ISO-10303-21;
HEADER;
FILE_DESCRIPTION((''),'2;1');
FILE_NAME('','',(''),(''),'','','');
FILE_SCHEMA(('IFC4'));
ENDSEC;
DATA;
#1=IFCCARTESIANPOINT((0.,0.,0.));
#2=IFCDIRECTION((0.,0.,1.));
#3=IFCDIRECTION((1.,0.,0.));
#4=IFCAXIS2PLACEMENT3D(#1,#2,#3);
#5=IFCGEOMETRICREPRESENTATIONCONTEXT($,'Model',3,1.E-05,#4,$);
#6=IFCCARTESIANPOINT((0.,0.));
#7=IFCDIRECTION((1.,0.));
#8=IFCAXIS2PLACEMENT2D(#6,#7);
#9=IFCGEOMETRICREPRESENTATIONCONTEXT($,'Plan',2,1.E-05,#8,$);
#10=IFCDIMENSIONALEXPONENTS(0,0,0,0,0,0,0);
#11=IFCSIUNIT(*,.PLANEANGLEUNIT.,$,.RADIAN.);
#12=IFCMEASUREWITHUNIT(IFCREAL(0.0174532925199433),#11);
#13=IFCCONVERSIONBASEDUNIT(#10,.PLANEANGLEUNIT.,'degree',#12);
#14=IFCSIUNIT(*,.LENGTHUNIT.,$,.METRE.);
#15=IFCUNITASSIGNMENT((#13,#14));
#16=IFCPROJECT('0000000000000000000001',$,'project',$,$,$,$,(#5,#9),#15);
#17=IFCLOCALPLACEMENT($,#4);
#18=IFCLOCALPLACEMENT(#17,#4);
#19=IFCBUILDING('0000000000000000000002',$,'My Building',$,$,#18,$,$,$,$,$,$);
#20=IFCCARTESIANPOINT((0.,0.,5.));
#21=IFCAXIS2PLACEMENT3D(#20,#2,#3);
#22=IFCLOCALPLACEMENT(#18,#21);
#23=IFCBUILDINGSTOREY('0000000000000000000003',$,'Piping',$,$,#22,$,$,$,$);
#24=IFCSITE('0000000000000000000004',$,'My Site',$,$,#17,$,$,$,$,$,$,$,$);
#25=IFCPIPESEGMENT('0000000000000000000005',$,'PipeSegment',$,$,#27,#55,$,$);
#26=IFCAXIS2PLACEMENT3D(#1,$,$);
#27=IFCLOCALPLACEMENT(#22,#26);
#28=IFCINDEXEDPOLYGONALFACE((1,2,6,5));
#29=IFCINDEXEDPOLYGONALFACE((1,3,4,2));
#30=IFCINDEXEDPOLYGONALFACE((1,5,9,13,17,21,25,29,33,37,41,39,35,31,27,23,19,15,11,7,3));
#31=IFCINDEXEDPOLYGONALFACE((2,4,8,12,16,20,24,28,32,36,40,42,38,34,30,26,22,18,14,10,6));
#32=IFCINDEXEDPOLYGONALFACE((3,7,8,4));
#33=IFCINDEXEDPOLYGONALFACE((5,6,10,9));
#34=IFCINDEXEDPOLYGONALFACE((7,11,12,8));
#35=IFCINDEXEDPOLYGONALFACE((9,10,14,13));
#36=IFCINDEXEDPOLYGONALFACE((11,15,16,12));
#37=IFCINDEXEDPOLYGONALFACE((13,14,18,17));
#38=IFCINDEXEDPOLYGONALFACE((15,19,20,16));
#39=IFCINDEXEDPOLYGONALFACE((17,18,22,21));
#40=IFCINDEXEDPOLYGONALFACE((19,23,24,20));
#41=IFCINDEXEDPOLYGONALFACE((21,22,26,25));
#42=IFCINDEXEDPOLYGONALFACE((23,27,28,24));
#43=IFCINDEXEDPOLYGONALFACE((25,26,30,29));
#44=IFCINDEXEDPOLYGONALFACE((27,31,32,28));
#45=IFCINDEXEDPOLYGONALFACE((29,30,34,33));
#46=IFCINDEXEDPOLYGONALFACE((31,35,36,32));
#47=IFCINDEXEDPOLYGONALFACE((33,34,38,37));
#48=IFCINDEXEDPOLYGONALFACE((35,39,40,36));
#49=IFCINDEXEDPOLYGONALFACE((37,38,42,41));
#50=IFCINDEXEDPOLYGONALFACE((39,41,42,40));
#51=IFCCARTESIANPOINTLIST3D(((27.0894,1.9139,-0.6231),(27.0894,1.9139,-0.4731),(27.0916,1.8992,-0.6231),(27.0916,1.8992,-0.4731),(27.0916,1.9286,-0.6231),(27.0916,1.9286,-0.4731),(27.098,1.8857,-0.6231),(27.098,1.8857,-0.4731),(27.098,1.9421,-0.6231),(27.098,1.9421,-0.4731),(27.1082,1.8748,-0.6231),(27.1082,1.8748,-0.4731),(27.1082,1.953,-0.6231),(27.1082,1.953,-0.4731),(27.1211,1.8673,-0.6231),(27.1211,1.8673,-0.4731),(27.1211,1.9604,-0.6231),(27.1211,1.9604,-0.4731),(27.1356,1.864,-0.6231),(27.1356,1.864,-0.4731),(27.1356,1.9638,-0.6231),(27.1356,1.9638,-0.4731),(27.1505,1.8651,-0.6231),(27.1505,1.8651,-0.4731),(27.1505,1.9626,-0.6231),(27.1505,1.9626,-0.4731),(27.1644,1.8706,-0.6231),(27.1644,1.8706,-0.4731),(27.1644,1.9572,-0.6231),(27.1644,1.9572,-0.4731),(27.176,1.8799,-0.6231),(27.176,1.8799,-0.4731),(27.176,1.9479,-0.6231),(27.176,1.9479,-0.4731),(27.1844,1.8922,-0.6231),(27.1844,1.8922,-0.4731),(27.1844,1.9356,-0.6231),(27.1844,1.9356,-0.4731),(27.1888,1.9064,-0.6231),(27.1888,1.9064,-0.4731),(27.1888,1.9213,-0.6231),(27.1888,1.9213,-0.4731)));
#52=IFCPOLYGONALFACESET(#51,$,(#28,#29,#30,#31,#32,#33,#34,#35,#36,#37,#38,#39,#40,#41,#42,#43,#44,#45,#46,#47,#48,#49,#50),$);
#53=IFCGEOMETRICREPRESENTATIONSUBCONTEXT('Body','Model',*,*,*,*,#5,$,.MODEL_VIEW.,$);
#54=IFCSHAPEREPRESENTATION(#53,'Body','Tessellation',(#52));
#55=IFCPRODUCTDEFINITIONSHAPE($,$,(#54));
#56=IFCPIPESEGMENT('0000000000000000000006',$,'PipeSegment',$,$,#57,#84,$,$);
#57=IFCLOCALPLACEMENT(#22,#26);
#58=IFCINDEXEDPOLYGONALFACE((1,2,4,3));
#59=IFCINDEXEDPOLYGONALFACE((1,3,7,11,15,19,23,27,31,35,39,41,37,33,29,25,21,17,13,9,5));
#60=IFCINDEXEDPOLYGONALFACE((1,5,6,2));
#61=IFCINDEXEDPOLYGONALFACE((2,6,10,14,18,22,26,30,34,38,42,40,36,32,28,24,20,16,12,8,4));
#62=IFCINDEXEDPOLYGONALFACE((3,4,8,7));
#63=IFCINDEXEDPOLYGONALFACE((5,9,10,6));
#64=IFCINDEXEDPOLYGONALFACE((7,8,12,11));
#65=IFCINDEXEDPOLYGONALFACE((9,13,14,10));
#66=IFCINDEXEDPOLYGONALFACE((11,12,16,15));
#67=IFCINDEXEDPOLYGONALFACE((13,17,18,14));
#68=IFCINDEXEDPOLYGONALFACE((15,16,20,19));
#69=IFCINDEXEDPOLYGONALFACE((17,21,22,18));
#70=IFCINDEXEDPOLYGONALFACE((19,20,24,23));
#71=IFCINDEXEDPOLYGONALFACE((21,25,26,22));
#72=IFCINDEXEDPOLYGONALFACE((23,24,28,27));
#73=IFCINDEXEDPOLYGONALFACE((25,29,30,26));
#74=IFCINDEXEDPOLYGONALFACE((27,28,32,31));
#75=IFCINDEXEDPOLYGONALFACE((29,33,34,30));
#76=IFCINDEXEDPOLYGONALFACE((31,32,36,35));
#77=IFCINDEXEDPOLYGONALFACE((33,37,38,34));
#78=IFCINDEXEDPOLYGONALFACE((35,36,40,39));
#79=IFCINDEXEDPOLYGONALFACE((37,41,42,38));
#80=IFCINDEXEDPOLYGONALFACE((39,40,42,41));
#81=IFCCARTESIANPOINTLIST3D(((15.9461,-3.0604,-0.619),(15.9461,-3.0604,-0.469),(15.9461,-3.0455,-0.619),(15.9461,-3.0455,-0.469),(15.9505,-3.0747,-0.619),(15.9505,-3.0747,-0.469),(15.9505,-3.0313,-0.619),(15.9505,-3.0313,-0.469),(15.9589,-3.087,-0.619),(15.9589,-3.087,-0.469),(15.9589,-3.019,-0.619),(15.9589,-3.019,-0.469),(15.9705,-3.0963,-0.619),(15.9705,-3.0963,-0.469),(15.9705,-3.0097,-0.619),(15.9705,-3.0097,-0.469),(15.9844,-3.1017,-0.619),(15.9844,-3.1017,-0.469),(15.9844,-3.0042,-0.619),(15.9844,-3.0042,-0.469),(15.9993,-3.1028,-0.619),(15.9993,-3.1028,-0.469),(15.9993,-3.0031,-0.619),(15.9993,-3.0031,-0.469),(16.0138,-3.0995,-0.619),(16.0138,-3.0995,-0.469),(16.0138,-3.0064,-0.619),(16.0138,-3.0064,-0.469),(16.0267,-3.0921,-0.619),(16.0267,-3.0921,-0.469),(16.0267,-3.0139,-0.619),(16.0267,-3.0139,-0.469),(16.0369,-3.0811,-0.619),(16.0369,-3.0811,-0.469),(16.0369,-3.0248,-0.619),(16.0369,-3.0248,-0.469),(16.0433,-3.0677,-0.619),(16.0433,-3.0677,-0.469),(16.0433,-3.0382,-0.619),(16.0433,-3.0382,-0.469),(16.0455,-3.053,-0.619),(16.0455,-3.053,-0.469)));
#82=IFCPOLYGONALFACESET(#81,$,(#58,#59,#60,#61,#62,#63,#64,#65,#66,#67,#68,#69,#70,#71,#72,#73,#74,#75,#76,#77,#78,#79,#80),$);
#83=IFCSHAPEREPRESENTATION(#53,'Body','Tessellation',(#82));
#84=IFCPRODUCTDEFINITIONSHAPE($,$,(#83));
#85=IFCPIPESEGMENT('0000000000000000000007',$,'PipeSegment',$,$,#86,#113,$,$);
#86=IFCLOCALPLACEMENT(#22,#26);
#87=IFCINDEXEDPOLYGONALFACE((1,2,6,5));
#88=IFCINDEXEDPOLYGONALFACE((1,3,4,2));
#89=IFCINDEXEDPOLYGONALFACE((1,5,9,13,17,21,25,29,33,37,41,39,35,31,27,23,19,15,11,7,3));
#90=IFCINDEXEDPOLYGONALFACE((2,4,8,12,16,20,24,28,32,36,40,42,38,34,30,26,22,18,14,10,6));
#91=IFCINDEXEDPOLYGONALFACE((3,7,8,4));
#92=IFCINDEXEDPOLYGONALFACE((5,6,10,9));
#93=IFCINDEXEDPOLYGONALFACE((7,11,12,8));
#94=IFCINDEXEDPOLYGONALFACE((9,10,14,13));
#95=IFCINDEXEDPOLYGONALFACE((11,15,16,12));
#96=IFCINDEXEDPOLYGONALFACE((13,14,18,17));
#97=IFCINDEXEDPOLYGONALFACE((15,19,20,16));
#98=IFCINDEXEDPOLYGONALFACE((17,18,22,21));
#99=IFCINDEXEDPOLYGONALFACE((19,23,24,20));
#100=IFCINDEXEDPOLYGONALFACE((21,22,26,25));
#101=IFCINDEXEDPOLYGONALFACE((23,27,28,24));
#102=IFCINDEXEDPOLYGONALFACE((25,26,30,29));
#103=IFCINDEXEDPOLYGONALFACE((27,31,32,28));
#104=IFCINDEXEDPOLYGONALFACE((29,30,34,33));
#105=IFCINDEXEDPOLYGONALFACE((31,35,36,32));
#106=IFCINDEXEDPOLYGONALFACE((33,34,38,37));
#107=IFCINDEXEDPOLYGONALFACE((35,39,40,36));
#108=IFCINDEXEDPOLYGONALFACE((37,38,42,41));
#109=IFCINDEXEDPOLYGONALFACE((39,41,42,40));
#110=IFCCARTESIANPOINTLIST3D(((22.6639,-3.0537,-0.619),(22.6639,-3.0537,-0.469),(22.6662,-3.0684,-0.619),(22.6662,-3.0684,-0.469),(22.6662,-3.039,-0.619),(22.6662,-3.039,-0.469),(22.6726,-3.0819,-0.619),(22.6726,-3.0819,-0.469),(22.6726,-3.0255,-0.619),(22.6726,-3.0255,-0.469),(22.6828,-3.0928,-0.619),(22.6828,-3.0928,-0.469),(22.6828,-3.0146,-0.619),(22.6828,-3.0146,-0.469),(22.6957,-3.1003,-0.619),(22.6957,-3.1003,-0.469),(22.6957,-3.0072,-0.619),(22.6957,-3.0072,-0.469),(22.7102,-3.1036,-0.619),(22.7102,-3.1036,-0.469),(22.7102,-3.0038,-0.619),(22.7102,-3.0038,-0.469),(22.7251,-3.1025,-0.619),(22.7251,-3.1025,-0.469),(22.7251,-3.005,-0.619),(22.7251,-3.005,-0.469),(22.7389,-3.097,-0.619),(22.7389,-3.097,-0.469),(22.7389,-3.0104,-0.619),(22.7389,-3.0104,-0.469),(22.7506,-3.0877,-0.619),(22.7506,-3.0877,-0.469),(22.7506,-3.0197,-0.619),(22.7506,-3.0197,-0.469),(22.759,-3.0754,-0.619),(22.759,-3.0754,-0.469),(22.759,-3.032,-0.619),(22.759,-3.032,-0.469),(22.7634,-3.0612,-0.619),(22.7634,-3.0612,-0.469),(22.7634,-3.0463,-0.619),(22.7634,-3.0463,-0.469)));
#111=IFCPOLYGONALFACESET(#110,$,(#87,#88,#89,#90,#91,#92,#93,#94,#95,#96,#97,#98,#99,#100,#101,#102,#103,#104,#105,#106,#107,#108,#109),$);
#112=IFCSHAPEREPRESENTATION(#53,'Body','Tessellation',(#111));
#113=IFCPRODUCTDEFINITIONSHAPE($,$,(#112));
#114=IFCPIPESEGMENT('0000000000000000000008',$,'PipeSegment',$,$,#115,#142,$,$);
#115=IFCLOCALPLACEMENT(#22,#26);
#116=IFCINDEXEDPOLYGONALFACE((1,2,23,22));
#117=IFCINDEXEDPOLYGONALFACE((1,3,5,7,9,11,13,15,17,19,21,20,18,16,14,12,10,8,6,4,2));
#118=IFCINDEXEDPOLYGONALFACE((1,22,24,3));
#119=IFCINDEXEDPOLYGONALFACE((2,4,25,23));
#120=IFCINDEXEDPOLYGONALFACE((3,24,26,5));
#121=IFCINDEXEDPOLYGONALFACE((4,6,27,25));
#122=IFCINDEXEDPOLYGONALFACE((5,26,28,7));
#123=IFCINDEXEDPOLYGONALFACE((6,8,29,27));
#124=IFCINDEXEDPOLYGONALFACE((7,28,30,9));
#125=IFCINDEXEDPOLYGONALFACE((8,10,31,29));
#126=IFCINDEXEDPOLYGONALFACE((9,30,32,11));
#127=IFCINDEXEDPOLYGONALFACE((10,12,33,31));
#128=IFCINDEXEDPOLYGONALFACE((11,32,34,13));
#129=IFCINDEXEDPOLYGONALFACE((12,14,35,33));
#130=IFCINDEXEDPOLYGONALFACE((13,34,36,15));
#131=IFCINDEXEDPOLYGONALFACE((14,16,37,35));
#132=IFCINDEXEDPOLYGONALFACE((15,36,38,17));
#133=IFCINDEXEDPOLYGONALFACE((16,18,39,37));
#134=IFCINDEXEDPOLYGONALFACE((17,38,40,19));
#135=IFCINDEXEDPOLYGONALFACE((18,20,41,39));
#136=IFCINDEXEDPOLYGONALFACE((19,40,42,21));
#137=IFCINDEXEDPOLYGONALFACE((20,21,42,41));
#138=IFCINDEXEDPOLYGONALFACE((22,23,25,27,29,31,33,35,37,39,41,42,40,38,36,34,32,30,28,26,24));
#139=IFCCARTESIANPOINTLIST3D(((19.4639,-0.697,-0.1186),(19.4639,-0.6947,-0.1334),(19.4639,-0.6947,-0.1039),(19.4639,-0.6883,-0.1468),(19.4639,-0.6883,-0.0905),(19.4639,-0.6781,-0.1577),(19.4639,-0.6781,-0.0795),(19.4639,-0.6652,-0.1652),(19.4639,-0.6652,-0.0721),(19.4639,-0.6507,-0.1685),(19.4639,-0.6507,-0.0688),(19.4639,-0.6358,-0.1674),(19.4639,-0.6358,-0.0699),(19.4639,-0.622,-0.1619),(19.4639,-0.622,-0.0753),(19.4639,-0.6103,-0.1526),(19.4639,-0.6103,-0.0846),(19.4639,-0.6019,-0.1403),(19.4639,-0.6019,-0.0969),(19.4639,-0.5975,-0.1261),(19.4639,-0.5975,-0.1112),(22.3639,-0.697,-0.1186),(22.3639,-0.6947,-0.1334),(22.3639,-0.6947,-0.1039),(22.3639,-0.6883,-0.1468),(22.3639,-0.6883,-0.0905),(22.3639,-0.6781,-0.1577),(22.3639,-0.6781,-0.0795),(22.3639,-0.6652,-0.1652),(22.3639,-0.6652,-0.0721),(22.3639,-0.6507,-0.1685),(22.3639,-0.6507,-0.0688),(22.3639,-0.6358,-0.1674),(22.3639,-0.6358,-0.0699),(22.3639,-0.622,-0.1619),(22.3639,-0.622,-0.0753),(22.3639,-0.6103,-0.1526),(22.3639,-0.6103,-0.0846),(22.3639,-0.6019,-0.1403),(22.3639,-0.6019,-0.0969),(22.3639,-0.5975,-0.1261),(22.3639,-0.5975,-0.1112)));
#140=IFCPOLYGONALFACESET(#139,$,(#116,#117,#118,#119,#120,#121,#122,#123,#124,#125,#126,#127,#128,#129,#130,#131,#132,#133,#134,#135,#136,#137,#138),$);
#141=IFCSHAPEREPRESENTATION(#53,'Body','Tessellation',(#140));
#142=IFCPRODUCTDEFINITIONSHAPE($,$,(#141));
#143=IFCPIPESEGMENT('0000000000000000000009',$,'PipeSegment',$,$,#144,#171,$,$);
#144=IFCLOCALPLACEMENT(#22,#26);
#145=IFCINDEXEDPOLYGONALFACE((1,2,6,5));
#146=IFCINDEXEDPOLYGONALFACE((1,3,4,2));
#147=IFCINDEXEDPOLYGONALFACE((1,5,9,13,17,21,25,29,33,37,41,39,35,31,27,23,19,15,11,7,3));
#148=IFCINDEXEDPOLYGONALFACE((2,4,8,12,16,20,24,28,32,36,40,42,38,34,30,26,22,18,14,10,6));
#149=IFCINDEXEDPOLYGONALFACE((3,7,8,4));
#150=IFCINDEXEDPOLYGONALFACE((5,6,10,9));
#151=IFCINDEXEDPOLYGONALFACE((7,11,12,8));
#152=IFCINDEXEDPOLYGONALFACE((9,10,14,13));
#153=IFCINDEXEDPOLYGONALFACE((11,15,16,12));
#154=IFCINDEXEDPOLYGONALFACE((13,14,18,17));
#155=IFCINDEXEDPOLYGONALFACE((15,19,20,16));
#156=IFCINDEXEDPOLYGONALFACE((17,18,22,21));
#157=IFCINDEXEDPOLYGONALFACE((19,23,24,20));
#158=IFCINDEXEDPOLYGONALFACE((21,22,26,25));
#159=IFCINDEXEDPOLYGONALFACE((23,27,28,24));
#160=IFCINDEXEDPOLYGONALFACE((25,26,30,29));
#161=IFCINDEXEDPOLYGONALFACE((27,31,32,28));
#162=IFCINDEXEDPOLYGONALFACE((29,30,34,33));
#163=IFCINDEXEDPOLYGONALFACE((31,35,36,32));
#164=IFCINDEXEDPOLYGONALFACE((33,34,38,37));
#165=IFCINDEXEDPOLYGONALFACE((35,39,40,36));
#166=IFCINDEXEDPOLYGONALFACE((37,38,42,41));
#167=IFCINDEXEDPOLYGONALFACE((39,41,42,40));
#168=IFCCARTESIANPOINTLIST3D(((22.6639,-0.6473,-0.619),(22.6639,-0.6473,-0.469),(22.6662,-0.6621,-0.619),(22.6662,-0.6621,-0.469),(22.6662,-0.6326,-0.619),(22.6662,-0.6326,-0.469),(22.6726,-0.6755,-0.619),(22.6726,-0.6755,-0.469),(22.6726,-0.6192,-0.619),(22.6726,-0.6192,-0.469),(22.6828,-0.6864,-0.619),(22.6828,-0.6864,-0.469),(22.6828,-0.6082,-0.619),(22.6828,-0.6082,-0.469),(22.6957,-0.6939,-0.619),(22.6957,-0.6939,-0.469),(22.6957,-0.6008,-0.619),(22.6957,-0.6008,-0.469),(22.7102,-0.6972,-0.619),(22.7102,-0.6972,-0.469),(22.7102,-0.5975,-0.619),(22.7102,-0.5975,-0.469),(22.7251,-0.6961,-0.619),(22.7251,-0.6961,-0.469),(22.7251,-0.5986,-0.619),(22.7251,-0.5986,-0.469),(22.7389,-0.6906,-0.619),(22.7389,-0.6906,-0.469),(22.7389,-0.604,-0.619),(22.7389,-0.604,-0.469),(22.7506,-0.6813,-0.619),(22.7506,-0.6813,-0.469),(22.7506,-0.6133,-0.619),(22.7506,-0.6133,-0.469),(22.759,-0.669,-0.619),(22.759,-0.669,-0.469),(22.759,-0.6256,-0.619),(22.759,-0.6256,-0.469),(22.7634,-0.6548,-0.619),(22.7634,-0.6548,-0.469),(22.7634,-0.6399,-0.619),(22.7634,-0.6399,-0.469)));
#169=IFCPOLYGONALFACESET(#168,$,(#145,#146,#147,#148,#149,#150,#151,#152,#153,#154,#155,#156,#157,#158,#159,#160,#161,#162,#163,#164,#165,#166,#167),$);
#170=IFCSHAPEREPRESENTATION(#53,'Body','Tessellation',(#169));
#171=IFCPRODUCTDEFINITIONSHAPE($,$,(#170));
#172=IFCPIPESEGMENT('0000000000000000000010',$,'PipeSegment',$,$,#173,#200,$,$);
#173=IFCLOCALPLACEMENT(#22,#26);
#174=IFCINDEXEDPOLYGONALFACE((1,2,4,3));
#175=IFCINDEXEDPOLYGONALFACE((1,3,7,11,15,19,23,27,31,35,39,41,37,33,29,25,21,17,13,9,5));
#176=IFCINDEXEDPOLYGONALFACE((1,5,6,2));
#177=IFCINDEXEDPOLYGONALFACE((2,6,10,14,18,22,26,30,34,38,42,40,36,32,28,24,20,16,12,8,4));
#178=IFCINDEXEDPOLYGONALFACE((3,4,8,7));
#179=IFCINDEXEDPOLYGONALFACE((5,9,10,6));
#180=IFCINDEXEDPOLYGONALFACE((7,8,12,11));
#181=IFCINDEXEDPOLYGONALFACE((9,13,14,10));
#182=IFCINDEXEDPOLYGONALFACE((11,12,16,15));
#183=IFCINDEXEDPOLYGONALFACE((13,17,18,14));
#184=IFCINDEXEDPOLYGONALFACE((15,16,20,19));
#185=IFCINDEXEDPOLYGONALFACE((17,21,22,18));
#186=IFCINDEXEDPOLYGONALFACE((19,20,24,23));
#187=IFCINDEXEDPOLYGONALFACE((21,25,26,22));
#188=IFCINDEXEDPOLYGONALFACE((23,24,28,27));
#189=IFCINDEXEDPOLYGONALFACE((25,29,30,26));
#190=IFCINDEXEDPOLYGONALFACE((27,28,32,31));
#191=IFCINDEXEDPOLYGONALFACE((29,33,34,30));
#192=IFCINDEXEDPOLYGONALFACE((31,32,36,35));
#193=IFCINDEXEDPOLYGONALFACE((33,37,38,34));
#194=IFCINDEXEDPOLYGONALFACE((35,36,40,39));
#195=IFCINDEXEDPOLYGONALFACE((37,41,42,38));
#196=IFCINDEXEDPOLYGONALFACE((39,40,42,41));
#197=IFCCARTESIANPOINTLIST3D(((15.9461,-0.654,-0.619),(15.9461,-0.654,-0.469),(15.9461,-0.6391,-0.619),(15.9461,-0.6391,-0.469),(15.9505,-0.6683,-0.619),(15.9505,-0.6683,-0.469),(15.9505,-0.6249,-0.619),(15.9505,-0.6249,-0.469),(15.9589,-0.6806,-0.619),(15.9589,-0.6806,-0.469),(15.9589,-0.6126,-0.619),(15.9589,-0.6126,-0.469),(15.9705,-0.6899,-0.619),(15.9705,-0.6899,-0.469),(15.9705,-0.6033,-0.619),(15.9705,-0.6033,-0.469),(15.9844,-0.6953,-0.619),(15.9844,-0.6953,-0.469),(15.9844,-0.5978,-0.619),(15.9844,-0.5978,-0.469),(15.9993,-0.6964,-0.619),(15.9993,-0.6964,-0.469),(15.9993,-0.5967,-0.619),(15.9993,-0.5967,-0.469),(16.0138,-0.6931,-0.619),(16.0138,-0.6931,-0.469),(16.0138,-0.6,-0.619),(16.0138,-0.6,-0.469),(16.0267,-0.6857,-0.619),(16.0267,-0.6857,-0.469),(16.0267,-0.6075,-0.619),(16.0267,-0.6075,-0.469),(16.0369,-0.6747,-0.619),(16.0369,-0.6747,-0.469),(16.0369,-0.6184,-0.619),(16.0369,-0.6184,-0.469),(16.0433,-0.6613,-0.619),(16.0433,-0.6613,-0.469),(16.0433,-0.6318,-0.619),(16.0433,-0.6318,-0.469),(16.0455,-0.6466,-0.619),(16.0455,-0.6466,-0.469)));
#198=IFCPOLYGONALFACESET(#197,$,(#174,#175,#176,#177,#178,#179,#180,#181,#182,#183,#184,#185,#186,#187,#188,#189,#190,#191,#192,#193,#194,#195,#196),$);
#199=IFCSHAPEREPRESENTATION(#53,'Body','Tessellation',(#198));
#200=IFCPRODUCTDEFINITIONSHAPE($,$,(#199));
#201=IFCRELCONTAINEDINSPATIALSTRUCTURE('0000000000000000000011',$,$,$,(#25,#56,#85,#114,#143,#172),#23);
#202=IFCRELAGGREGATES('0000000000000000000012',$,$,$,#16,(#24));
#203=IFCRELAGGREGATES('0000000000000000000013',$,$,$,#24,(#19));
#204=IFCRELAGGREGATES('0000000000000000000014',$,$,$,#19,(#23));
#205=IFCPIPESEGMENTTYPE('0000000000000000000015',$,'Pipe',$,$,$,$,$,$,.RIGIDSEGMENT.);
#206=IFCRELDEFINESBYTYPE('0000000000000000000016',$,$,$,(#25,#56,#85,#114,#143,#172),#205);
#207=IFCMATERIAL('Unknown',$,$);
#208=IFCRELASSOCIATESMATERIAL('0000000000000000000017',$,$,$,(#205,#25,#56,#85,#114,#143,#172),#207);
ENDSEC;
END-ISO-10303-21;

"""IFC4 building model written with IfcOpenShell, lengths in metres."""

from ifc_helpers import new_model, entity, si_unit, converted_unit, frame, origin_with_axes, origin_2d_with_axis, place, context, subcontext, project, spatial, circle, extrude, material, material_profile, profile_set, profile_usage, type_object, element, save


model = new_model("IFC4")

# Units and contexts
model_context = context("Model", 3, precision=1e-05, world=origin_with_axes())
plan_context = context("Plan", 2, precision=1e-05, world=origin_2d_with_axis())
body_context = subcontext(model_context, "Body", "Model", "MODEL_VIEW")
ifc_project = project(units=[converted_unit("PLANEANGLEUNIT", "degree", entity("IfcReal", 0.0174532925199433), si_unit("PLANEANGLEUNIT", "RADIAN"), dimensions=[0, 0, 0, 0, 0, 0, 0]), si_unit("LENGTHUNIT", "METRE")], contexts=[model_context, plan_context])

# Site, building, storey
site_placement = place(None, origin_with_axes())
site = spatial("IfcSite", under=ifc_project, at=site_placement, Name="My Site")
building_placement = place(site_placement, origin_with_axes())
building = spatial("IfcBuilding", under=site, at=building_placement, Name="My Building")
storey_placement = place(building_placement, frame((0.0, 0.0, 5.0), z_axis=(0.0, 0.0, 1.0), x_axis=(1.0, 0.0, 0.0)))
storey = spatial("IfcBuildingStorey", under=building, at=storey_placement, Name="Piping")

# Pipe segments
ifc_material = material(Name="Unknown")
ifc_material_profile_1 = material_profile(ifc_material, circle(Radius=0.05))
ifc_profile_set_1 = profile_set([ifc_material_profile_1])
pipe_segment_type = type_object("IfcPipeSegmentType", Name="Pipe", PredefinedType="RIGIDSEGMENT", material=ifc_profile_set_1)
ifc_profile_usage_1 = profile_usage(ifc_profile_set_1, cardinal=5)
pipe_segment_1_placement = place(storey_placement, frame((27.1394, 1.9139, -0.4731), z_axis=(0.0, 0.0, -1.0), x_axis=(-1.0, 0.0, 0.0)))
element("IfcPipeSegment", 1, at=pipe_segment_1_placement, inside=storey, type_object=pipe_segment_type, material=ifc_profile_usage_1, Name="PipeSegment", context=body_context, shape_type="SweptSolid", body=[
    extrude(circle(Radius=0.05), origin_with_axes(), (0.0, 0.0, 1.0), 0.15),
])
ifc_profile_usage_2 = profile_usage(ifc_profile_set_1, cardinal=5)
pipe_segment_2_placement = place(storey_placement, frame((15.9955, -3.053, -0.469), z_axis=(0.0, 0.0, -1.0), x_axis=(1.0, -0.000053, 0.0)))
element("IfcPipeSegment", 2, at=pipe_segment_2_placement, inside=storey, type_object=pipe_segment_type, material=ifc_profile_usage_2, Name="PipeSegment", context=body_context, shape_type="SweptSolid", body=[
    extrude(circle(Radius=0.05), origin_with_axes(), (0.0, 0.0, 1.0), 0.15),
])
ifc_profile_usage_3 = profile_usage(ifc_profile_set_1, cardinal=5)
pipe_segment_3_placement = place(storey_placement, frame((22.7139, -3.0537, -0.469), z_axis=(0.0, 0.0, -1.0), x_axis=(-1.0, 0.0, 0.0)))
element("IfcPipeSegment", 3, at=pipe_segment_3_placement, inside=storey, type_object=pipe_segment_type, material=ifc_profile_usage_3, Name="PipeSegment", context=body_context, shape_type="SweptSolid", body=[
    extrude(circle(Radius=0.05), origin_with_axes(), (0.0, 0.0, 1.0), 0.15),
])
ifc_profile_usage_4 = profile_usage(ifc_profile_set_1, cardinal=5)
pipe_segment_4_placement = place(storey_placement, frame((22.3639, -0.647, -0.1186), z_axis=(-1.0, 0.0, 0.0), x_axis=(0.0, -1.0, 0.0)))
element("IfcPipeSegment", 4, at=pipe_segment_4_placement, inside=storey, type_object=pipe_segment_type, material=ifc_profile_usage_4, Name="PipeSegment", context=body_context, shape_type="SweptSolid", body=[
    extrude(circle(Radius=0.05), origin_with_axes(), (0.0, 0.0, 1.0), 2.9),
])
ifc_profile_usage_5 = profile_usage(ifc_profile_set_1, cardinal=5)
pipe_segment_5_placement = place(storey_placement, frame((22.7139, -0.6473, -0.469), z_axis=(0.0, 0.0, -1.0), x_axis=(-1.0, 0.0, 0.0)))
element("IfcPipeSegment", 5, at=pipe_segment_5_placement, inside=storey, type_object=pipe_segment_type, material=ifc_profile_usage_5, Name="PipeSegment", context=body_context, shape_type="SweptSolid", body=[
    extrude(circle(Radius=0.05), origin_with_axes(), (0.0, 0.0, 1.0), 0.15),
])
ifc_profile_usage_6 = profile_usage(ifc_profile_set_1, cardinal=5)
pipe_segment_6_placement = place(storey_placement, frame((15.9955, -0.6466, -0.469), z_axis=(0.0, 0.0, -1.0), x_axis=(1.0, -0.000053, 0.0)))
element("IfcPipeSegment", 6, at=pipe_segment_6_placement, inside=storey, type_object=pipe_segment_type, material=ifc_profile_usage_6, Name="PipeSegment", context=body_context, shape_type="SweptSolid", body=[
    extrude(circle(Radius=0.05), origin_with_axes(), (0.0, 0.0, 1.0), 0.15),
])

save(model, "model.ifc")
